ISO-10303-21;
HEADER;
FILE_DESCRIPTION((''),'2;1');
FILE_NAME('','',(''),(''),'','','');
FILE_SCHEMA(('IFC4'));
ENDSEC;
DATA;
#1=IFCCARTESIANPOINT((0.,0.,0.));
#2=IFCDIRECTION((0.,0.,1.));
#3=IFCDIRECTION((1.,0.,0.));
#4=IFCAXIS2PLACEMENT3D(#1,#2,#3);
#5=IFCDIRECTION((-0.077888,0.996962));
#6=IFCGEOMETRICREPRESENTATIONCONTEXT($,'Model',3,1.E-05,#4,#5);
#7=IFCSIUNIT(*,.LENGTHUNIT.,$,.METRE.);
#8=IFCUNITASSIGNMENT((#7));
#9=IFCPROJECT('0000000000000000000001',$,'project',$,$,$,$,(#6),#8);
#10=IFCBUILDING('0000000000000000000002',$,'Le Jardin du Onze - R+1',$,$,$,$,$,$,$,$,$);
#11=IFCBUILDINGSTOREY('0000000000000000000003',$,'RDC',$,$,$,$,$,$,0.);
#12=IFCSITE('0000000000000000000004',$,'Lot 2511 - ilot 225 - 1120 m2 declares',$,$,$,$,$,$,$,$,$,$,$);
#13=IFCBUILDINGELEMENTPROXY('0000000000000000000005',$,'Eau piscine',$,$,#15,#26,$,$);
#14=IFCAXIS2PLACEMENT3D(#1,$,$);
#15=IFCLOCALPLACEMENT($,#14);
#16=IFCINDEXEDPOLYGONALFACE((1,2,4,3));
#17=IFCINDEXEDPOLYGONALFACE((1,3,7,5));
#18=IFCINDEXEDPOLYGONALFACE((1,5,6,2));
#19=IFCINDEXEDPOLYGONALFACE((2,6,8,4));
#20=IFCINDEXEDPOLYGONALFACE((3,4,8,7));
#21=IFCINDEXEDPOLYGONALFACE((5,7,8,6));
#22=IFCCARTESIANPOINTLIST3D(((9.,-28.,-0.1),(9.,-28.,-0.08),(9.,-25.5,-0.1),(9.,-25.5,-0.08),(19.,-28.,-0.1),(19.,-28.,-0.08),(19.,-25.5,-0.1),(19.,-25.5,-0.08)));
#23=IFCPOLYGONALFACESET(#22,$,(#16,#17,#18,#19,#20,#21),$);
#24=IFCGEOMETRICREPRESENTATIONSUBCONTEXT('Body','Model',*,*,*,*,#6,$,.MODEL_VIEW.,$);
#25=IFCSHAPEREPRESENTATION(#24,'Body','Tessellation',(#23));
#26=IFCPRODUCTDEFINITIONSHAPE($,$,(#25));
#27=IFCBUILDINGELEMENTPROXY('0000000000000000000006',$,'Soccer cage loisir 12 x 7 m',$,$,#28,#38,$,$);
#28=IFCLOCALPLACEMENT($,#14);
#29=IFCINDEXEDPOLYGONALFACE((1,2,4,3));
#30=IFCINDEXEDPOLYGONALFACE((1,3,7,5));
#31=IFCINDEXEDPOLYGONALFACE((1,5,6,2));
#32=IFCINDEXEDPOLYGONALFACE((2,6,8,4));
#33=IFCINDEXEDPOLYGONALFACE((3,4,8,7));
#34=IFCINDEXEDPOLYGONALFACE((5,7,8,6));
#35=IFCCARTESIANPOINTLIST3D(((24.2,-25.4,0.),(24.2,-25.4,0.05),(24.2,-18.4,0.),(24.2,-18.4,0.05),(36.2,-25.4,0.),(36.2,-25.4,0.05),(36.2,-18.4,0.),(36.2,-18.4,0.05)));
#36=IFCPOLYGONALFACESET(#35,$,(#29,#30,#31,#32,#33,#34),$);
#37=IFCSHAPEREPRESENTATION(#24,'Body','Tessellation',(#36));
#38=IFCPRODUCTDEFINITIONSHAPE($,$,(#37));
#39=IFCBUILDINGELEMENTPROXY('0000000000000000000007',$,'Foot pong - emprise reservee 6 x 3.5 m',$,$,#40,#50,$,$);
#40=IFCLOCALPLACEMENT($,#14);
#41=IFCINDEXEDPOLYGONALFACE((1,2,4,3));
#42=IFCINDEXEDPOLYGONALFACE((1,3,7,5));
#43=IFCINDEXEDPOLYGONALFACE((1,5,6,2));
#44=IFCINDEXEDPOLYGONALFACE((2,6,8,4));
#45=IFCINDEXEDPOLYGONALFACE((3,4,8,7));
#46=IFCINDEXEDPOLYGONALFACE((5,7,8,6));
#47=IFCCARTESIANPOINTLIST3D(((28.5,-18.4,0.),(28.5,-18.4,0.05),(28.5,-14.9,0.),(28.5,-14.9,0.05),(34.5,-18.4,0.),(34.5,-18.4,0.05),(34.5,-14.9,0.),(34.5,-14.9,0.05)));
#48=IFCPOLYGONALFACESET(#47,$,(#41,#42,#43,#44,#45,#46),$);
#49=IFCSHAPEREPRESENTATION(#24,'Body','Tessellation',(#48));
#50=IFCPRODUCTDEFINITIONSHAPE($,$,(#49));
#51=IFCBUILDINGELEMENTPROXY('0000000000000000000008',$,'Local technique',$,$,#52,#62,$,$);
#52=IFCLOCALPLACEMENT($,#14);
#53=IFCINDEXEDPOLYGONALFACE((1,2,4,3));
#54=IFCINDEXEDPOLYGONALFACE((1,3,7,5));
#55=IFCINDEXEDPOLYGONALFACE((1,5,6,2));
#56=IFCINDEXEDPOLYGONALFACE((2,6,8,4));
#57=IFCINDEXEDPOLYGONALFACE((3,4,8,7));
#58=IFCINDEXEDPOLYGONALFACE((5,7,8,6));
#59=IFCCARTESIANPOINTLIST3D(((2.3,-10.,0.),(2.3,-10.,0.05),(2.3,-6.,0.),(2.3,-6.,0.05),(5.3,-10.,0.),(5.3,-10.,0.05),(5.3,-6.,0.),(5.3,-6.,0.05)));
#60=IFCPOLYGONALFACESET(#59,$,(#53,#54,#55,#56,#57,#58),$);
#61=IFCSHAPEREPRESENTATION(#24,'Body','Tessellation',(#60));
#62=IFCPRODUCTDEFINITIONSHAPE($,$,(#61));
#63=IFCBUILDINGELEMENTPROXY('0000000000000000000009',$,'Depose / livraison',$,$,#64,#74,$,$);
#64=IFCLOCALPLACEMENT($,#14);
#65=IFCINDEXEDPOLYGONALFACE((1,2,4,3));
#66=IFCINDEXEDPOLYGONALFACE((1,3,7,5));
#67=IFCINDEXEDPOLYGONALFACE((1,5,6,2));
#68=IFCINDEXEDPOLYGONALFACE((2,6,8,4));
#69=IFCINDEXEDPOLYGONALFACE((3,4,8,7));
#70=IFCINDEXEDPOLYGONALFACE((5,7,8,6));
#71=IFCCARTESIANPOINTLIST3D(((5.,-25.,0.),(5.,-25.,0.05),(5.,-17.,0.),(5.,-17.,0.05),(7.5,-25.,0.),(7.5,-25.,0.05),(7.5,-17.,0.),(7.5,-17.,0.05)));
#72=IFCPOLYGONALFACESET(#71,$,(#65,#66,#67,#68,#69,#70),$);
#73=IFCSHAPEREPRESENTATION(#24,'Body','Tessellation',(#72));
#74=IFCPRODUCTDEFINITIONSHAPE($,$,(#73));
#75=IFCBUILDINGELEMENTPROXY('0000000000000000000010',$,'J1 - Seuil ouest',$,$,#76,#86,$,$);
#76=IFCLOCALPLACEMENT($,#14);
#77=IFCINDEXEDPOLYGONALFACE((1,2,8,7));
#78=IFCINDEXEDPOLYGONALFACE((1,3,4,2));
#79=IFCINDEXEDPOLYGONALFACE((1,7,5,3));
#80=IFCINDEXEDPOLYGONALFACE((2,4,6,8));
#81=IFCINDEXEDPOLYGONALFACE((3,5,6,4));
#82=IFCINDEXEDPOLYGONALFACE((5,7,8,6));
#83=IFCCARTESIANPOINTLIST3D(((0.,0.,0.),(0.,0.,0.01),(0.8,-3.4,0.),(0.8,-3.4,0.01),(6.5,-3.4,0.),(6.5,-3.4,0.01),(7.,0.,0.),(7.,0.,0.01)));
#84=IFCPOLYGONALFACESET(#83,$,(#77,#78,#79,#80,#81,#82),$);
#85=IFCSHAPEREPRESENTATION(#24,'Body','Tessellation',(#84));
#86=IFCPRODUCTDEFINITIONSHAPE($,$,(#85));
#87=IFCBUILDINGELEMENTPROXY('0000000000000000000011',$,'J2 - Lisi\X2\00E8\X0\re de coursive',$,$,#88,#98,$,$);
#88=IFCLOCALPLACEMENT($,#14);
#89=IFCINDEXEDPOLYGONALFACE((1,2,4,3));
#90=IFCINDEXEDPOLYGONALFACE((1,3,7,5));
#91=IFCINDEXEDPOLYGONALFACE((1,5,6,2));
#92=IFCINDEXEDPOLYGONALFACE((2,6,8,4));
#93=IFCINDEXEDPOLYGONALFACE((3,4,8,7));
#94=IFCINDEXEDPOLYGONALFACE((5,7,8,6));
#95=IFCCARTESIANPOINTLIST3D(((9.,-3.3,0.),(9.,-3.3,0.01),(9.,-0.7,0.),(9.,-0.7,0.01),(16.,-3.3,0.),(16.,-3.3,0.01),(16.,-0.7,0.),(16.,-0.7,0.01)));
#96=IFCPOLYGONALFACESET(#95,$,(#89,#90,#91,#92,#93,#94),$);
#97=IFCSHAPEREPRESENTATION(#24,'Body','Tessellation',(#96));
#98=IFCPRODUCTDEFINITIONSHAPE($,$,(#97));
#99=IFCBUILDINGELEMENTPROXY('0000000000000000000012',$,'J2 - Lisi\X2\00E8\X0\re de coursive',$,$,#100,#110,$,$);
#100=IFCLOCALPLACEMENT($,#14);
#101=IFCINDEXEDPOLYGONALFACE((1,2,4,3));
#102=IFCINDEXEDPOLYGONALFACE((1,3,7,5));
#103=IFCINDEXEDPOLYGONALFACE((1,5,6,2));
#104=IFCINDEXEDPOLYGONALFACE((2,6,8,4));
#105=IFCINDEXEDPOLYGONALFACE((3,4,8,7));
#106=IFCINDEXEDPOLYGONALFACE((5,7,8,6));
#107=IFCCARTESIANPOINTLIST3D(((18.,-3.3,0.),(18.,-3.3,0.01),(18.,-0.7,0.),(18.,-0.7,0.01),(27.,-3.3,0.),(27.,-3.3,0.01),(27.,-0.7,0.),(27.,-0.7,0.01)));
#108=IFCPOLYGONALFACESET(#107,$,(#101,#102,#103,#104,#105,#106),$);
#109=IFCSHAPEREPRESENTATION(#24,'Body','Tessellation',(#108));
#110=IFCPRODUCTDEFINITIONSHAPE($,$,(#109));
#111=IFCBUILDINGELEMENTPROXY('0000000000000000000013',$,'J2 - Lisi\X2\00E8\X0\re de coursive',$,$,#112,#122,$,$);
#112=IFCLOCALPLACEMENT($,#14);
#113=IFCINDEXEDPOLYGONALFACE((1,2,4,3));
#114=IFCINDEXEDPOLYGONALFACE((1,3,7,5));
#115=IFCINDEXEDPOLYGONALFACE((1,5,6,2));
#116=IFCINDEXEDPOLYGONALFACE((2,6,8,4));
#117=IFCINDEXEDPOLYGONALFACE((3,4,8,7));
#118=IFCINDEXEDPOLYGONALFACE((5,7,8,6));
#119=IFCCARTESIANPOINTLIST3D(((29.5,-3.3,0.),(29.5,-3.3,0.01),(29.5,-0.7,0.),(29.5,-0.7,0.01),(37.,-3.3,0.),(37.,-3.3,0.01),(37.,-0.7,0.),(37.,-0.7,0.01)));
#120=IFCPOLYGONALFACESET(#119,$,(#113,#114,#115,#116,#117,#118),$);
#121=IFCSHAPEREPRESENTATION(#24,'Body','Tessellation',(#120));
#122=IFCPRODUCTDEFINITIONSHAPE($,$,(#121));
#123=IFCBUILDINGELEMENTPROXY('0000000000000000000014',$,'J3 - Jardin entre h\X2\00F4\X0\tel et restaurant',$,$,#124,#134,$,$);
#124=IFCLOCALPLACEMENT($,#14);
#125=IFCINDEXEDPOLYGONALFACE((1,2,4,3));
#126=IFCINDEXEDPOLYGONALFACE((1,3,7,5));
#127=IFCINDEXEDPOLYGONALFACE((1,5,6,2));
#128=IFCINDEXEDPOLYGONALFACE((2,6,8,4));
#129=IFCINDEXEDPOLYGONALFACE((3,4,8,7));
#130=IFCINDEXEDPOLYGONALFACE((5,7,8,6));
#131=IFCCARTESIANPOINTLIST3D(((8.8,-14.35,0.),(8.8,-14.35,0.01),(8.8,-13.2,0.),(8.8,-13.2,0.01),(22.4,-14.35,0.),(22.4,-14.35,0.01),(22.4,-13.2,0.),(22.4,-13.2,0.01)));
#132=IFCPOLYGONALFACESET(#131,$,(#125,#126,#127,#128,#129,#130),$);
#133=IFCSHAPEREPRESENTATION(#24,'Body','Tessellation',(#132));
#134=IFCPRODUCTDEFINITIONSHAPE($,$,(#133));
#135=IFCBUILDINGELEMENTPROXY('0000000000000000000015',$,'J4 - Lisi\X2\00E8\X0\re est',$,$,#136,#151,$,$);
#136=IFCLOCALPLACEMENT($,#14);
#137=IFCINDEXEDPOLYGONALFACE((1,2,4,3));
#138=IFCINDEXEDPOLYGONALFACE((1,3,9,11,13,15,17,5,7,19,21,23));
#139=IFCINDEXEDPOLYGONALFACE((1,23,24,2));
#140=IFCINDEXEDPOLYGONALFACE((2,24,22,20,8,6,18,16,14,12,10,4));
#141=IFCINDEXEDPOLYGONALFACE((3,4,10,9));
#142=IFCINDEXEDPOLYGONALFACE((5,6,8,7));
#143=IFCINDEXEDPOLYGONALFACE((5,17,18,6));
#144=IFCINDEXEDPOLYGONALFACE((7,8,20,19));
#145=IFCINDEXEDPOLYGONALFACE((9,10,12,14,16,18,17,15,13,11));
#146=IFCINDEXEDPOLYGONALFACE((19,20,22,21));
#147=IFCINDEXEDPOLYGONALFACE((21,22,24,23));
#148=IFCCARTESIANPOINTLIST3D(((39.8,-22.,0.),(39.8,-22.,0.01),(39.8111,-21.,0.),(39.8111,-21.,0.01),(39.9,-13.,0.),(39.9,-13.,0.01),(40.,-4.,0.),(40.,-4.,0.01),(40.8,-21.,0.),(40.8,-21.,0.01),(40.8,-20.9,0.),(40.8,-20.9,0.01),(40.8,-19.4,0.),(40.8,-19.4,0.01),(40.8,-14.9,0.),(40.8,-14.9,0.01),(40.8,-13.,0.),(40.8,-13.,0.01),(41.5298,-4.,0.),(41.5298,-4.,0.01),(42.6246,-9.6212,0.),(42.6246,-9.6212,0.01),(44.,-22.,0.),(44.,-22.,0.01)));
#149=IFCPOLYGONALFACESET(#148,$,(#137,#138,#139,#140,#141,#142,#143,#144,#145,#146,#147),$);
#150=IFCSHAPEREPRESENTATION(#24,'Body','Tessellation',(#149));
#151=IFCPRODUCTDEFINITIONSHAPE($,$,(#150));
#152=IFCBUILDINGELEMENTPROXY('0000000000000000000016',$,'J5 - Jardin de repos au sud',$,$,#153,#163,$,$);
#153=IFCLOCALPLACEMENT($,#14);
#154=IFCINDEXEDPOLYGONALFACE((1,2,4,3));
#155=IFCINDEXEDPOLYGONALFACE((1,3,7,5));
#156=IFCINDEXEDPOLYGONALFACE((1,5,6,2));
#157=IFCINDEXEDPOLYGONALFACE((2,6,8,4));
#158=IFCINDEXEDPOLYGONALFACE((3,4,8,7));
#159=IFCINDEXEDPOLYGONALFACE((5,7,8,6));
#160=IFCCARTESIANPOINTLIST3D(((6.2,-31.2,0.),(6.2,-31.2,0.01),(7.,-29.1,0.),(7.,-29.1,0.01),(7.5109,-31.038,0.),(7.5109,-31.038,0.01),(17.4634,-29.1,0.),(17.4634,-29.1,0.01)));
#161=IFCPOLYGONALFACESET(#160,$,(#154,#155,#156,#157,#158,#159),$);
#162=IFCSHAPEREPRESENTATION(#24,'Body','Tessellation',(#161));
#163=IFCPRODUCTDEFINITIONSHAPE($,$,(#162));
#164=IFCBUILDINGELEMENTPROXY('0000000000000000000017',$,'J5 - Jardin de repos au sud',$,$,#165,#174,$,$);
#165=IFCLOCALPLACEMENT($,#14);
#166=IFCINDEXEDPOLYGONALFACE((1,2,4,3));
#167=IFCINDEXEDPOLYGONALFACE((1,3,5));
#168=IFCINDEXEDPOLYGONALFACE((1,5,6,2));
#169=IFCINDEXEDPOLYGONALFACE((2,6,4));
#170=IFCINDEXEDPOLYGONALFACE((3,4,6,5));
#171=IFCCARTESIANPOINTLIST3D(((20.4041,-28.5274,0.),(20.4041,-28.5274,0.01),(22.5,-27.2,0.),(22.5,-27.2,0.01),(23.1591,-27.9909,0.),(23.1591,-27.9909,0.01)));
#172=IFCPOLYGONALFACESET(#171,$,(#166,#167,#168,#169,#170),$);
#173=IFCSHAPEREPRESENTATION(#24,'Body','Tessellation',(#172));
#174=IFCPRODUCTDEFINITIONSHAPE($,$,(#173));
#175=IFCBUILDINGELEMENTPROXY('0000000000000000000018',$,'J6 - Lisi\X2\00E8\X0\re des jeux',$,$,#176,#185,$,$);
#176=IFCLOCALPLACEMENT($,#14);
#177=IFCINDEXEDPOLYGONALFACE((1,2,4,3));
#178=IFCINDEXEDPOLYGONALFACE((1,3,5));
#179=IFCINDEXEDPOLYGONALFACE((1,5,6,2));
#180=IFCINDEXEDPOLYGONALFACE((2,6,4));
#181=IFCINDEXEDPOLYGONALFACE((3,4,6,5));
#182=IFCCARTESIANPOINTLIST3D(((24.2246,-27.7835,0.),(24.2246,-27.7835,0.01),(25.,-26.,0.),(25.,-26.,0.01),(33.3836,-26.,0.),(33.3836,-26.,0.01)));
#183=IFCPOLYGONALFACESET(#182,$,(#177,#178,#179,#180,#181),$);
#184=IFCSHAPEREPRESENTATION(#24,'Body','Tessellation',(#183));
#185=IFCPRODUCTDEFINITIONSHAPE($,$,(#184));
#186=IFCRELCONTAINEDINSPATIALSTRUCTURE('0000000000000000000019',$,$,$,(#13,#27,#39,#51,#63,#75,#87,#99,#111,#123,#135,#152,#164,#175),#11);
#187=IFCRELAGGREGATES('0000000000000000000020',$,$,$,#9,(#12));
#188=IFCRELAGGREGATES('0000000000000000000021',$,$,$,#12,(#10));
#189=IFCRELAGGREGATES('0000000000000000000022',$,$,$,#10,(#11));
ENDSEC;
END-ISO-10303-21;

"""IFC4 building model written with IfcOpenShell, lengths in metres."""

from ifc_helpers import new_model, si_unit, direction, frame, origin, origin_with_axes, place, context, subcontext, project, spatial, polyline, outline, extrude, element, save


model = new_model("IFC4")

# Units and contexts
model_context = context("Model", 3, precision=1e-05, world=origin_with_axes(), true_north=direction((-0.077888, 0.996962)))
body_context = subcontext(model_context, "Body", "Model", "MODEL_VIEW")
ifc_project = project(units=[si_unit("LENGTHUNIT", "METRE")], contexts=[model_context])

# Site, building, storey
site = spatial("IfcSite", under=ifc_project, Name="Lot 2511 - ilot 225 - 1120 m2 declares")
building = spatial("IfcBuilding", under=site, Name="Le Jardin du Onze - R+1")
storey = spatial("IfcBuildingStorey", under=building, Name="RDC", Elevation=0.0)

# Building element proxies
proxy_1_placement = place(None, origin_with_axes())
element("IfcBuildingElementProxy", 1, at=proxy_1_placement, inside=storey, Name="Eau piscine", context=body_context, shape_type="SweptSolid", body=[
    extrude(outline(polyline([(19.0, -28.0), (19.0, -25.5), (9.0, -25.5), (9.0, -28.0), (19.0, -28.0)])), frame((0.0, 0.0, -0.1)), (0.0, 0.0, 1.0), 0.02),
])
proxy_2_placement = place(None, origin_with_axes())
element("IfcBuildingElementProxy", 2, at=proxy_2_placement, inside=storey, Name="Soccer cage loisir 12 x 7 m", context=body_context, shape_type="SweptSolid", body=[
    extrude(outline(polyline([(36.2, -25.4), (36.2, -18.4), (24.2, -18.4), (24.2, -25.4), (36.2, -25.4)])), origin(), (0.0, 0.0, 1.0), 0.05),
])
proxy_3_placement = place(None, origin_with_axes())
element("IfcBuildingElementProxy", 3, at=proxy_3_placement, inside=storey, Name="Foot pong - emprise reservee 6 x 3.5 m", context=body_context, shape_type="SweptSolid", body=[
    extrude(outline(polyline([(34.5, -18.4), (34.5, -14.9), (28.5, -14.9), (28.5, -18.4), (34.5, -18.4)])), origin(), (0.0, 0.0, 1.0), 0.05),
])
proxy_4_placement = place(None, origin_with_axes())
element("IfcBuildingElementProxy", 4, at=proxy_4_placement, inside=storey, Name="Local technique", context=body_context, shape_type="SweptSolid", body=[
    extrude(outline(polyline([(5.3, -10.0), (5.3, -6.0), (2.3, -6.0), (2.3, -10.0), (5.3, -10.0)])), origin(), (0.0, 0.0, 1.0), 0.05),
])
proxy_5_placement = place(None, origin_with_axes())
element("IfcBuildingElementProxy", 5, at=proxy_5_placement, inside=storey, Name="Depose / livraison", context=body_context, shape_type="SweptSolid", body=[
    extrude(outline(polyline([(7.5, -25.0), (7.5, -17.0), (5.0, -17.0), (5.0, -25.0), (7.5, -25.0)])), origin(), (0.0, 0.0, 1.0), 0.05),
])
proxy_6_placement = place(None, origin_with_axes())
element("IfcBuildingElementProxy", 6, at=proxy_6_placement, inside=storey, Name="J1 - Seuil ouest", context=body_context, shape_type="SweptSolid", body=[
    extrude(outline(polyline([(7.0, 0.0), (6.5, -3.4), (0.8, -3.4), (0.0, 0.0), (7.0, 0.0)])), origin(), (0.0, 0.0, 1.0), 0.01),
])
proxy_7_placement = place(None, origin_with_axes())
element("IfcBuildingElementProxy", 7, at=proxy_7_placement, inside=storey, Name="J2 - Lisière de coursive", context=body_context, shape_type="SweptSolid", body=[
    extrude(outline(polyline([(9.0, -0.7), (16.0, -0.7), (16.0, -3.3), (9.0, -3.3), (9.0, -0.7)])), origin(), (0.0, 0.0, 1.0), 0.01),
])
proxy_8_placement = place(None, origin_with_axes())
element("IfcBuildingElementProxy", 8, at=proxy_8_placement, inside=storey, Name="J2 - Lisière de coursive", context=body_context, shape_type="SweptSolid", body=[
    extrude(outline(polyline([(27.0, -0.7), (27.0, -3.3), (18.0, -3.3), (18.0, -0.7), (27.0, -0.7)])), origin(), (0.0, 0.0, 1.0), 0.01),
])
proxy_9_placement = place(None, origin_with_axes())
element("IfcBuildingElementProxy", 9, at=proxy_9_placement, inside=storey, Name="J2 - Lisière de coursive", context=body_context, shape_type="SweptSolid", body=[
    extrude(outline(polyline([(37.0, -0.7), (37.0, -3.3), (29.5, -3.3), (29.5, -0.7), (37.0, -0.7)])), origin(), (0.0, 0.0, 1.0), 0.01),
])
proxy_10_placement = place(None, origin_with_axes())
element("IfcBuildingElementProxy", 10, at=proxy_10_placement, inside=storey, Name="J3 - Jardin entre hôtel et restaurant", context=body_context, shape_type="SweptSolid", body=[
    extrude(outline(polyline([(8.8, -14.35), (8.8, -13.2), (22.4, -13.2), (22.4, -14.35), (8.8, -14.35)])), origin(), (0.0, 0.0, 1.0), 0.01),
])
proxy_11_placement = place(None, origin_with_axes())
element("IfcBuildingElementProxy", 11, at=proxy_11_placement, inside=storey, Name="J4 - Lisière est", context=body_context, shape_type="SweptSolid", body=[
    extrude(outline(polyline([(41.5298, -4.0), (42.6246, -9.6212), (44.0, -22.0), (39.8, -22.0), (39.8111, -21.0), (40.8, -21.0), (40.8, -20.9), (40.8, -20.9), (40.8, -19.4), (40.8, -19.4), (40.8, -14.9), (40.8, -13.0), (39.9, -13.0), (40.0, -4.0), (41.5298, -4.0)])), origin(), (0.0, 0.0, 1.0), 0.01),
])
proxy_12_placement = place(None, origin_with_axes())
element("IfcBuildingElementProxy", 12, at=proxy_12_placement, inside=storey, Name="J5 - Jardin de repos au sud", context=body_context, shape_type="SweptSolid", body=[
    extrude(outline(polyline([(17.4634, -29.1), (7.5109, -31.038), (6.2, -31.2), (7.0, -29.1), (17.4634, -29.1)])), origin(), (0.0, 0.0, 1.0), 0.01),
])
proxy_13_placement = place(None, origin_with_axes())
element("IfcBuildingElementProxy", 13, at=proxy_13_placement, inside=storey, Name="J5 - Jardin de repos au sud", context=body_context, shape_type="SweptSolid", body=[
    extrude(outline(polyline([(22.5, -27.2), (23.1591, -27.9909), (20.4041, -28.5274), (22.5, -27.2)])), origin(), (0.0, 0.0, 1.0), 0.01),
])
proxy_14_placement = place(None, origin_with_axes())
element("IfcBuildingElementProxy", 14, at=proxy_14_placement, inside=storey, Name="J6 - Lisière des jeux", context=body_context, shape_type="SweptSolid", body=[
    extrude(outline(polyline([(33.3836, -26.0), (24.2246, -27.7835), (25.0, -26.0), (33.3836, -26.0)])), origin(), (0.0, 0.0, 1.0), 0.01),
])

save(model, "model.ifc")
